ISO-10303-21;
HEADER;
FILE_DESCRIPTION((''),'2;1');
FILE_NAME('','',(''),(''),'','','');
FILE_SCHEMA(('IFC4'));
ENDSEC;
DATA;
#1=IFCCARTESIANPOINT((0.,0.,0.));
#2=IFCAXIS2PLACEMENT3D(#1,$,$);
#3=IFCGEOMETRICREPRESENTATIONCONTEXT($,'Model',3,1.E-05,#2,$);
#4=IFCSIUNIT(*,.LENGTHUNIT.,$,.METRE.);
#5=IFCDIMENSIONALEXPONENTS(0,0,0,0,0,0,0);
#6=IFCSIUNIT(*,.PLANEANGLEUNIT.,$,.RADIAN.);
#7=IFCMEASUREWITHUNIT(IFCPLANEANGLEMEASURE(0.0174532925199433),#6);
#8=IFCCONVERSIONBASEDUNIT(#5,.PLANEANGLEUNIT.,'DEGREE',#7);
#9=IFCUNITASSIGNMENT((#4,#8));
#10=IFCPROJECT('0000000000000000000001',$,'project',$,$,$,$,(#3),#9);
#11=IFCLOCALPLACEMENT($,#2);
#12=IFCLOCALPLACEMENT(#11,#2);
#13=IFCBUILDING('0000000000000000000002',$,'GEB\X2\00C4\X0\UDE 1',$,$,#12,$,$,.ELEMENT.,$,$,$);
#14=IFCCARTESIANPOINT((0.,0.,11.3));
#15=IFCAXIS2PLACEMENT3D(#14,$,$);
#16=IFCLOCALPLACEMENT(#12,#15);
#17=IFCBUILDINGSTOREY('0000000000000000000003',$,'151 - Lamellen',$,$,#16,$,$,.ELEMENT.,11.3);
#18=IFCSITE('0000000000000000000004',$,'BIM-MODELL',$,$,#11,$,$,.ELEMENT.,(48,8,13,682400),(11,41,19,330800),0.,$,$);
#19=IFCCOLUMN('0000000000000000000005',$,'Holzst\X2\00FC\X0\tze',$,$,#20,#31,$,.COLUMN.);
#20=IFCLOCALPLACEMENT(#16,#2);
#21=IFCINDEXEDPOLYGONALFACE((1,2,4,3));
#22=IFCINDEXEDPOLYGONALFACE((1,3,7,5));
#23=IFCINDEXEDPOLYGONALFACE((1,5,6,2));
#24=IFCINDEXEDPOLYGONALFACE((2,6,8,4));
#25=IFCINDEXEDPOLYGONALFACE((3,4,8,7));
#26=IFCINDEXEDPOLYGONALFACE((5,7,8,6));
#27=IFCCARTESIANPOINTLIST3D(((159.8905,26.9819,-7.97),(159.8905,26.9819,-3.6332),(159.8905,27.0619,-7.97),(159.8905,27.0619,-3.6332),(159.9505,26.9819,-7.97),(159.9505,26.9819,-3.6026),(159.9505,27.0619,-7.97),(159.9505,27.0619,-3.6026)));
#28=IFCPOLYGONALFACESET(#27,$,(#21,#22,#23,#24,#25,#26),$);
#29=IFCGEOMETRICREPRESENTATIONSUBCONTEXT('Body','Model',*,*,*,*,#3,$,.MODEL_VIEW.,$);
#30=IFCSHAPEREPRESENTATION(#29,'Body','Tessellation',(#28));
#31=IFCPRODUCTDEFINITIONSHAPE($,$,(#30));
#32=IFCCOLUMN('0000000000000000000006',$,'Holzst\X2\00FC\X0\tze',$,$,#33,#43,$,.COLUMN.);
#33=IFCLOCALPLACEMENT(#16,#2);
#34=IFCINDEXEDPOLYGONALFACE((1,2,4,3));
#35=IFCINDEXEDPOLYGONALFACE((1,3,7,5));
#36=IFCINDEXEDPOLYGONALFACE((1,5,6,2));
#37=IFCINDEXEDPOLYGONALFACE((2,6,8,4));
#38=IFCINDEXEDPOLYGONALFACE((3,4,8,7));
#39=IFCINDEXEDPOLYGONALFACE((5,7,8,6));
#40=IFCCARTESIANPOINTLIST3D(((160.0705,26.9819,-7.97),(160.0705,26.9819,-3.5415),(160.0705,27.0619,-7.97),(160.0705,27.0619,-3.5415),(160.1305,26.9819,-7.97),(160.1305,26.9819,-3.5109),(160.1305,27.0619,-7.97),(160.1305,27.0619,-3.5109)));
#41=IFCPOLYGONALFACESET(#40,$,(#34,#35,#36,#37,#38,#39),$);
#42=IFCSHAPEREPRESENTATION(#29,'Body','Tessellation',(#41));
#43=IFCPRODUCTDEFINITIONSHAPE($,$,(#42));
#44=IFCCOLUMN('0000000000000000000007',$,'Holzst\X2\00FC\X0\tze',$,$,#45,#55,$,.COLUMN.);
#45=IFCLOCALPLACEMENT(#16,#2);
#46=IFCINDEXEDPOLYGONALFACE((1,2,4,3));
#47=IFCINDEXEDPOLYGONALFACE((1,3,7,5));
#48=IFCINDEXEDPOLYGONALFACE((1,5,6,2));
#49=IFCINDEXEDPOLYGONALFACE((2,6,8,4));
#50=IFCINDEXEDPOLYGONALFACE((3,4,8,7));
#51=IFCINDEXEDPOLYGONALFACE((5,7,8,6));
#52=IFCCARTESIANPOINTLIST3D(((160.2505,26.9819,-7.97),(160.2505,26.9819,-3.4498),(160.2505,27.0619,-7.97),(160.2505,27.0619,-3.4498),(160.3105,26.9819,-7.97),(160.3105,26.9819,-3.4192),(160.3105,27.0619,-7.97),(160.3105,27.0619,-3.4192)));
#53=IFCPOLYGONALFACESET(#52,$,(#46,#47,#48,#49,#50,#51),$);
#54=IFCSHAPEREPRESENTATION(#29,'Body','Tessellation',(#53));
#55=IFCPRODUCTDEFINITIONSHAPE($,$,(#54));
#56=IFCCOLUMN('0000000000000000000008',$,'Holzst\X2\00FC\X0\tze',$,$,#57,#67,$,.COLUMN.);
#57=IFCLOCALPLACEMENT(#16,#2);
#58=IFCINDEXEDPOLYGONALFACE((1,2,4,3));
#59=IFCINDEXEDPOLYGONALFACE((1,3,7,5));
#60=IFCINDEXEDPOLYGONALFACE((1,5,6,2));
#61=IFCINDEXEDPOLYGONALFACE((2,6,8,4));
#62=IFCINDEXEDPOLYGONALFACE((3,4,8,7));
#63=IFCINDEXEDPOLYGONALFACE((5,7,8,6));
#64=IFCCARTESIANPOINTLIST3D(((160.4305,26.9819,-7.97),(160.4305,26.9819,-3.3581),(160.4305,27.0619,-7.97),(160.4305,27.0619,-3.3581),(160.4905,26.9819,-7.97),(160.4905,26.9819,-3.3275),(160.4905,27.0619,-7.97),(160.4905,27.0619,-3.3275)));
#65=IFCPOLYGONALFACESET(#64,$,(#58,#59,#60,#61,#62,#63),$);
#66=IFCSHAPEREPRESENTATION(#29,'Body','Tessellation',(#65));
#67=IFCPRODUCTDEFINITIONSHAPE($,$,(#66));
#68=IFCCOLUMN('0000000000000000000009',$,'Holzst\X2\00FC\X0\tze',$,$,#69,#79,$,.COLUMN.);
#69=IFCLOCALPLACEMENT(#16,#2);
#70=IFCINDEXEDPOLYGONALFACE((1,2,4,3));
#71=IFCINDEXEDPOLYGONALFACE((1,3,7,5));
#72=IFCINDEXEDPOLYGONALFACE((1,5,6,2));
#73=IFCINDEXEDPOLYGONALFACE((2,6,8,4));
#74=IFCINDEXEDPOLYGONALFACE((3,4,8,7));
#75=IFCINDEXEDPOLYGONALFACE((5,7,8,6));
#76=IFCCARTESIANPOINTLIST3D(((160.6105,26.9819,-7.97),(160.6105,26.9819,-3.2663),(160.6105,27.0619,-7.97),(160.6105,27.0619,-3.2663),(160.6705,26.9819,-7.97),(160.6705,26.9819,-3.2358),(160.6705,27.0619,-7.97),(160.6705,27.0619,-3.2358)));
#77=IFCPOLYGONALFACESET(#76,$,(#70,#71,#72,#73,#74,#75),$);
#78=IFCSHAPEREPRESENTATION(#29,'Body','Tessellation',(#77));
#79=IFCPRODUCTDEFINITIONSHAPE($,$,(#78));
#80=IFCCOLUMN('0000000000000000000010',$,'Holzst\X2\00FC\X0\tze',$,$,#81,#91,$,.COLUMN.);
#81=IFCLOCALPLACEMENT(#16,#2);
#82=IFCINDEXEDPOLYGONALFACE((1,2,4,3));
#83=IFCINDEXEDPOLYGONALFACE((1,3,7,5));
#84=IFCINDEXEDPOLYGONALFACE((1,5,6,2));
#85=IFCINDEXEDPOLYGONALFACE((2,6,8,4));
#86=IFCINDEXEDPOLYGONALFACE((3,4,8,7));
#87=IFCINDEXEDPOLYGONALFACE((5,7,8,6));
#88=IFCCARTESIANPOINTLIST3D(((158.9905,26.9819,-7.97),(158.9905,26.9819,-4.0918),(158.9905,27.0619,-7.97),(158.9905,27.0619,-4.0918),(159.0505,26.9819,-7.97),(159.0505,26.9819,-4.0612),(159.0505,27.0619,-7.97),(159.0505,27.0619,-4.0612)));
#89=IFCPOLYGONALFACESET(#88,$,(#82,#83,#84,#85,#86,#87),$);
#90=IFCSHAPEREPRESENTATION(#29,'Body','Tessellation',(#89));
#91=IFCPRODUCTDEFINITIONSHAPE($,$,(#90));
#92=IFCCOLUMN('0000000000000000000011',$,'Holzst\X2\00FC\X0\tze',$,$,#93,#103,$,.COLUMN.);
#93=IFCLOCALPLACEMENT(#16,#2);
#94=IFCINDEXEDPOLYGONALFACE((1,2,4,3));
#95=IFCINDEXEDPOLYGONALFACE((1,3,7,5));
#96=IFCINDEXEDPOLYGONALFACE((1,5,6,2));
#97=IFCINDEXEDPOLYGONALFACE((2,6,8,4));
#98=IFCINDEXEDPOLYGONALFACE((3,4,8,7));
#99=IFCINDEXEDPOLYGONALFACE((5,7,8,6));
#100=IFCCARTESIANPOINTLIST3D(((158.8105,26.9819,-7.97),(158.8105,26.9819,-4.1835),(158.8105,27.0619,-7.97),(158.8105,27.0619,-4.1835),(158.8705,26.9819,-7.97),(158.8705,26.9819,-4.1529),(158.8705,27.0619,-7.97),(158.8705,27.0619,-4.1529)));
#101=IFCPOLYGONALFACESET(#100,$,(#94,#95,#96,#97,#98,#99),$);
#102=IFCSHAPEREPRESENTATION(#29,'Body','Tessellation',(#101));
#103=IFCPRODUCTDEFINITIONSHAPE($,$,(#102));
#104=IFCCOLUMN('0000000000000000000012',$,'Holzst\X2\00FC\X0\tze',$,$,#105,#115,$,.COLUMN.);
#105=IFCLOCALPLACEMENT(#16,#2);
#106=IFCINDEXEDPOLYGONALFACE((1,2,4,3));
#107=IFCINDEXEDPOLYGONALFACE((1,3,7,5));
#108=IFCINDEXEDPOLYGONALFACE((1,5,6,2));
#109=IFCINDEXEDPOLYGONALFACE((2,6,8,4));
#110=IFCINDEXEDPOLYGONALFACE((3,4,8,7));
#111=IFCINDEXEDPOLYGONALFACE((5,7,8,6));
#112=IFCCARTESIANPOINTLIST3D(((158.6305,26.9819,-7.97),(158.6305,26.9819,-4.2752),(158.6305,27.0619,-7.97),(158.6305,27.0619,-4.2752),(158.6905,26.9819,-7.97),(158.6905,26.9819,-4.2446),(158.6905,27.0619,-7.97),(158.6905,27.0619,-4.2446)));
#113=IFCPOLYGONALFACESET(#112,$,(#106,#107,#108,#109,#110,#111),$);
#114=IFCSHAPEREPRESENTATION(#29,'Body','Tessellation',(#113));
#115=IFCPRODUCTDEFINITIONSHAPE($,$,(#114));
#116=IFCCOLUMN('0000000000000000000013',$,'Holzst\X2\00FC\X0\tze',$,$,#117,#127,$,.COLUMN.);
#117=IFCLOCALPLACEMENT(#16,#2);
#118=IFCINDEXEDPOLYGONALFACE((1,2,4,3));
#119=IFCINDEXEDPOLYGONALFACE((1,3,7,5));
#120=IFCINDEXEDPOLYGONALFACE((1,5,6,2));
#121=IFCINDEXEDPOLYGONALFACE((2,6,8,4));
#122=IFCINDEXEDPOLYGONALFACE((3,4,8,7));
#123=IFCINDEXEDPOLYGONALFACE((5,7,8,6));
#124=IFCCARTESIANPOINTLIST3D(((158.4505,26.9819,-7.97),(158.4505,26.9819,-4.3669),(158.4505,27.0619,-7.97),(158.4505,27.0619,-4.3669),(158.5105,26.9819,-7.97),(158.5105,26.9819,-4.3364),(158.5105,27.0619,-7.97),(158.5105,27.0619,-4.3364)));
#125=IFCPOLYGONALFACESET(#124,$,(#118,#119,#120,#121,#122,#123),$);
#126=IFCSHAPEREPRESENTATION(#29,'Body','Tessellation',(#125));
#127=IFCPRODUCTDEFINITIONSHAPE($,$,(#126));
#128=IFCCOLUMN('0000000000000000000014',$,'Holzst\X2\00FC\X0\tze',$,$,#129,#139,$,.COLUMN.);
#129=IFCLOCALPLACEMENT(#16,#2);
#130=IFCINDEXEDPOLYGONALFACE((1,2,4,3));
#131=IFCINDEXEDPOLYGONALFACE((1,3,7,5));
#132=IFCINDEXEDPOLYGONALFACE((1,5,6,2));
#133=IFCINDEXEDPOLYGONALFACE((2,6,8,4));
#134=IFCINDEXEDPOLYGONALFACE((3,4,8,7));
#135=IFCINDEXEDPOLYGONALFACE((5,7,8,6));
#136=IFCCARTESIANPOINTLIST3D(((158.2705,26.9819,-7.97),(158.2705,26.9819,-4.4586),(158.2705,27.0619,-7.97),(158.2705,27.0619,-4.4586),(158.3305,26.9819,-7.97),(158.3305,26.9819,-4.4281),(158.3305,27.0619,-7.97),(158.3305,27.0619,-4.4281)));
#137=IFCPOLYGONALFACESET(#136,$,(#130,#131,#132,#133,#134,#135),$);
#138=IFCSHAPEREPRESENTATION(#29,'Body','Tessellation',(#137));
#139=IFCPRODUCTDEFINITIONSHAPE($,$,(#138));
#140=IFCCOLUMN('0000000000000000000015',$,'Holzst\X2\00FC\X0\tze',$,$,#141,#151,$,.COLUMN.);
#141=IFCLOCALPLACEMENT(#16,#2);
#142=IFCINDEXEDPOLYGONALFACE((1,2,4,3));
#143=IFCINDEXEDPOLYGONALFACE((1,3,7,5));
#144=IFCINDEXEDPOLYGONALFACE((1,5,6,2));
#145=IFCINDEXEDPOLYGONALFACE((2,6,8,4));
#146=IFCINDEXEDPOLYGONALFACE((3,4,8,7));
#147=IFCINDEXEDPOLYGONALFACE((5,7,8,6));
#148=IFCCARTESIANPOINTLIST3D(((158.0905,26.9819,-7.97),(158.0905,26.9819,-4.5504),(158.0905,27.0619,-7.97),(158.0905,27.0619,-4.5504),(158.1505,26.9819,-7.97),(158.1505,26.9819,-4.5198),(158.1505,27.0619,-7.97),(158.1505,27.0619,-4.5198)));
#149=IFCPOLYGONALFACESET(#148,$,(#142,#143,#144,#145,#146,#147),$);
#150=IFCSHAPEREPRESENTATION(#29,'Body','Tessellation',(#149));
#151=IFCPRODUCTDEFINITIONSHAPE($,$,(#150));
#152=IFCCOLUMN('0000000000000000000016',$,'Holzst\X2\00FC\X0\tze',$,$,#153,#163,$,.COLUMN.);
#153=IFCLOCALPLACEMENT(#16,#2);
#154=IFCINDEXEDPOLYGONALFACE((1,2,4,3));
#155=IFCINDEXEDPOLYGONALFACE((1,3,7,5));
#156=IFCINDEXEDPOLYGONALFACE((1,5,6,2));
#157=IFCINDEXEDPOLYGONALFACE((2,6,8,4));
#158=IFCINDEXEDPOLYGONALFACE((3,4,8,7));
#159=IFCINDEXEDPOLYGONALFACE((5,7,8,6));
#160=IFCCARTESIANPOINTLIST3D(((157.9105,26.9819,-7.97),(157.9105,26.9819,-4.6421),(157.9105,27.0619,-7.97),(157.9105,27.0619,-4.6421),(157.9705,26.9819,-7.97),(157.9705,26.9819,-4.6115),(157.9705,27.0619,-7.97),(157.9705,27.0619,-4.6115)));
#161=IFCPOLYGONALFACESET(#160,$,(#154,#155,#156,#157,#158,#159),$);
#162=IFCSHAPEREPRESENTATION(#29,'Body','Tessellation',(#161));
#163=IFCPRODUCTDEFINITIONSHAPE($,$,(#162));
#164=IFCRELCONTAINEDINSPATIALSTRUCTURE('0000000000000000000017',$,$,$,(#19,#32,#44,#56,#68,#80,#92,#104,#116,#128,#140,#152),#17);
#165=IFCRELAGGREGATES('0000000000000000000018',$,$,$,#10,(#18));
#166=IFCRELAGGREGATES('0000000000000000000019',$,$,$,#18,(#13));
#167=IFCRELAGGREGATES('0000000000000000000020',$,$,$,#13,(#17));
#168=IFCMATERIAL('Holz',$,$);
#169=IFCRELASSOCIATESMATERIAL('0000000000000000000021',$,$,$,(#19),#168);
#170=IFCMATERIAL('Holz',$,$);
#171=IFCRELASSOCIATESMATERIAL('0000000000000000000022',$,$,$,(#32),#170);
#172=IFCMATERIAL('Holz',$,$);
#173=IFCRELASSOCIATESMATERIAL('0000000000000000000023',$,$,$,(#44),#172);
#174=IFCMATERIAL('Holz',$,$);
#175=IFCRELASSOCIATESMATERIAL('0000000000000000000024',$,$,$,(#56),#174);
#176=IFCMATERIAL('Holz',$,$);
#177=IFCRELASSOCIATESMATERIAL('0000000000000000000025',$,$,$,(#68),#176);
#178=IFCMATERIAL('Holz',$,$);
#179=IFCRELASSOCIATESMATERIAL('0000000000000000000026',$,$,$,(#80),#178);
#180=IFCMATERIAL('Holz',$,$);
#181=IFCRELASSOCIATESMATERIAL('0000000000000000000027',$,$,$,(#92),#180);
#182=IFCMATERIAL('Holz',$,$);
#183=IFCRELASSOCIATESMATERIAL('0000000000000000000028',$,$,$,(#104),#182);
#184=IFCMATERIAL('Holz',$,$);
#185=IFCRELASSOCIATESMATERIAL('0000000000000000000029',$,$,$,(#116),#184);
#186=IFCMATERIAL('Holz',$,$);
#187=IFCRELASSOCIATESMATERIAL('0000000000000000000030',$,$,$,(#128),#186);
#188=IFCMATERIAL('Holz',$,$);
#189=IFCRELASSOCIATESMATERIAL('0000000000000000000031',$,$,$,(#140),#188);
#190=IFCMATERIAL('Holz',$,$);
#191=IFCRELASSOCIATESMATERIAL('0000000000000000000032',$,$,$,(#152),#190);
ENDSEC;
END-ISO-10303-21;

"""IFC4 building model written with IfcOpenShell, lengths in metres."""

from ifc_helpers import new_model, entity, si_unit, converted_unit, frame, frame_2d, origin, origin_with_axes, place, context, subcontext, project, spatial, rectangle, extrude, clip, halfspace, material, element, save


model = new_model("IFC4")

# Units and contexts
model_context = context("Model", 3, precision=1e-05, world=origin())
body_context = subcontext(model_context, "Body", "Model", "MODEL_VIEW")
ifc_project = project(units=[si_unit("LENGTHUNIT", "METRE"), converted_unit("PLANEANGLEUNIT", "DEGREE", entity("IfcPlaneAngleMeasure", 0.0174532925199433), si_unit("PLANEANGLEUNIT", "RADIAN"), dimensions=[0, 0, 0, 0, 0, 0, 0])], contexts=[model_context])

# Site, building, storey
site_placement = place(None, origin())
site = spatial("IfcSite", under=ifc_project, at=site_placement, Name="BIM-MODELL", CompositionType="ELEMENT", RefLatitude=(48, 8, 13, 682400), RefLongitude=(11, 41, 19, 330800), RefElevation=0.0)
building_placement = place(site_placement, origin())
building = spatial("IfcBuilding", under=site, at=building_placement, Name="GEBÄUDE 1", CompositionType="ELEMENT")
storey_placement = place(building_placement, frame((0.0, 0.0, 11.3)))
storey = spatial("IfcBuildingStorey", under=building, at=storey_placement, Name="151 - Lamellen", CompositionType="ELEMENT", Elevation=11.3)

# Columns
ifc_material_1 = material(Name="Holz")
column_1_placement = place(storey_placement, frame((159.8905, 26.9819, -7.97)))
element("IfcColumn", 1, at=column_1_placement, inside=storey, material=ifc_material_1, Name="Holzstütze", PredefinedType="COLUMN", context=body_context, shape_type="Clipping", body=[
    clip(extrude(rectangle(XDim=0.06, YDim=0.08, at=frame_2d((0.03, 0.04), x_axis=(1.0, 0.0))), origin_with_axes(), (0.0, 0.0, 1.0), 4.3674), halfspace(frame((0.03, 0.04, 4.3521), z_axis=(0.45399, 0.0, -0.891007), x_axis=(0.0, -1.0, 0.0)), True)),
])
ifc_material_2 = material(Name="Holz")
column_2_placement = place(storey_placement, frame((160.0705, 26.9819, -7.97)))
element("IfcColumn", 2, at=column_2_placement, inside=storey, material=ifc_material_2, Name="Holzstütze", PredefinedType="COLUMN", context=body_context, shape_type="Clipping", body=[
    clip(extrude(rectangle(XDim=0.06, YDim=0.08, at=frame_2d((0.03, 0.04), x_axis=(1.0, 0.0))), origin_with_axes(), (0.0, 0.0, 1.0), 4.4591), halfspace(frame((0.03, 0.04, 4.4438), z_axis=(0.45399, 0.0, -0.891007), x_axis=(0.0, -1.0, 0.0)), True)),
])
ifc_material_3 = material(Name="Holz")
column_3_placement = place(storey_placement, frame((160.2505, 26.9819, -7.97)))
element("IfcColumn", 3, at=column_3_placement, inside=storey, material=ifc_material_3, Name="Holzstütze", PredefinedType="COLUMN", context=body_context, shape_type="Clipping", body=[
    clip(extrude(rectangle(XDim=0.06, YDim=0.08, at=frame_2d((0.03, 0.04), x_axis=(1.0, 0.0))), origin_with_axes(), (0.0, 0.0, 1.0), 4.5508), halfspace(frame((0.03, 0.04, 4.5355), z_axis=(0.45399, 0.0, -0.891007), x_axis=(0.0, -1.0, 0.0)), True)),
])
ifc_material_4 = material(Name="Holz")
column_4_placement = place(storey_placement, frame((160.4305, 26.9819, -7.97)))
element("IfcColumn", 4, at=column_4_placement, inside=storey, material=ifc_material_4, Name="Holzstütze", PredefinedType="COLUMN", context=body_context, shape_type="Clipping", body=[
    clip(extrude(rectangle(XDim=0.06, YDim=0.08, at=frame_2d((0.03, 0.04), x_axis=(1.0, 0.0))), origin_with_axes(), (0.0, 0.0, 1.0), 4.6425), halfspace(frame((0.03, 0.04, 4.6272), z_axis=(0.45399, 0.0, -0.891007), x_axis=(0.0, -1.0, 0.0)), True)),
])
ifc_material_5 = material(Name="Holz")
column_5_placement = place(storey_placement, frame((160.6105, 26.9819, -7.97)))
element("IfcColumn", 5, at=column_5_placement, inside=storey, material=ifc_material_5, Name="Holzstütze", PredefinedType="COLUMN", context=body_context, shape_type="Clipping", body=[
    clip(extrude(rectangle(XDim=0.06, YDim=0.08, at=frame_2d((0.03, 0.04), x_axis=(1.0, 0.0))), origin_with_axes(), (0.0, 0.0, 1.0), 4.7342), halfspace(frame((0.03, 0.04, 4.7189), z_axis=(0.45399, 0.0, -0.891007), x_axis=(0.0, -1.0, 0.0)), True)),
])
ifc_material_6 = material(Name="Holz")
column_6_placement = place(storey_placement, frame((158.9905, 26.9819, -7.97)))
element("IfcColumn", 6, at=column_6_placement, inside=storey, material=ifc_material_6, Name="Holzstütze", PredefinedType="COLUMN", context=body_context, shape_type="Clipping", body=[
    clip(extrude(rectangle(XDim=0.06, YDim=0.08, at=frame_2d((0.03, 0.04), x_axis=(1.0, 0.0))), origin_with_axes(), (0.0, 0.0, 1.0), 3.9088), halfspace(frame((0.03, 0.04, 3.8935), z_axis=(0.45399, 0.0, -0.891007), x_axis=(0.0, -1.0, 0.0)), True)),
])
ifc_material_7 = material(Name="Holz")
column_7_placement = place(storey_placement, frame((158.8105, 26.9819, -7.97)))
element("IfcColumn", 7, at=column_7_placement, inside=storey, material=ifc_material_7, Name="Holzstütze", PredefinedType="COLUMN", context=body_context, shape_type="Clipping", body=[
    clip(extrude(rectangle(XDim=0.06, YDim=0.08, at=frame_2d((0.03, 0.04), x_axis=(1.0, 0.0))), origin_with_axes(), (0.0, 0.0, 1.0), 3.8171), halfspace(frame((0.03, 0.04, 3.8018), z_axis=(0.45399, 0.0, -0.891007), x_axis=(0.0, -1.0, 0.0)), True)),
])
ifc_material_8 = material(Name="Holz")
column_8_placement = place(storey_placement, frame((158.6305, 26.9819, -7.97)))
element("IfcColumn", 8, at=column_8_placement, inside=storey, material=ifc_material_8, Name="Holzstütze", PredefinedType="COLUMN", context=body_context, shape_type="Clipping", body=[
    clip(extrude(rectangle(XDim=0.06, YDim=0.08, at=frame_2d((0.03, 0.04), x_axis=(1.0, 0.0))), origin_with_axes(), (0.0, 0.0, 1.0), 3.7254), halfspace(frame((0.03, 0.04, 3.7101), z_axis=(0.45399, 0.0, -0.891007), x_axis=(0.0, -1.0, 0.0)), True)),
])
ifc_material_9 = material(Name="Holz")
column_9_placement = place(storey_placement, frame((158.4505, 26.9819, -7.97)))
element("IfcColumn", 9, at=column_9_placement, inside=storey, material=ifc_material_9, Name="Holzstütze", PredefinedType="COLUMN", context=body_context, shape_type="Clipping", body=[
    clip(extrude(rectangle(XDim=0.06, YDim=0.08, at=frame_2d((0.03, 0.04), x_axis=(1.0, 0.0))), origin_with_axes(), (0.0, 0.0, 1.0), 3.6336), halfspace(frame((0.03, 0.04, 3.6184), z_axis=(0.45399, 0.0, -0.891007), x_axis=(0.0, -1.0, 0.0)), True)),
])
ifc_material_10 = material(Name="Holz")
column_10_placement = place(storey_placement, frame((158.2705, 26.9819, -7.97)))
element("IfcColumn", 10, at=column_10_placement, inside=storey, material=ifc_material_10, Name="Holzstütze", PredefinedType="COLUMN", context=body_context, shape_type="Clipping", body=[
    clip(extrude(rectangle(XDim=0.06, YDim=0.08, at=frame_2d((0.03, 0.04), x_axis=(1.0, 0.0))), origin_with_axes(), (0.0, 0.0, 1.0), 3.5419), halfspace(frame((0.03, 0.04, 3.5266), z_axis=(0.45399, 0.0, -0.891007), x_axis=(0.0, -1.0, 0.0)), True)),
])
ifc_material_11 = material(Name="Holz")
column_11_placement = place(storey_placement, frame((158.0905, 26.9819, -7.97)))
element("IfcColumn", 11, at=column_11_placement, inside=storey, material=ifc_material_11, Name="Holzstütze", PredefinedType="COLUMN", context=body_context, shape_type="Clipping", body=[
    clip(extrude(rectangle(XDim=0.06, YDim=0.08, at=frame_2d((0.03, 0.04), x_axis=(1.0, 0.0))), origin_with_axes(), (0.0, 0.0, 1.0), 3.4502), halfspace(frame((0.03, 0.04, 3.4349), z_axis=(0.45399, 0.0, -0.891007), x_axis=(0.0, -1.0, 0.0)), True)),
])
ifc_material_12 = material(Name="Holz")
column_12_placement = place(storey_placement, frame((157.9105, 26.9819, -7.97)))
element("IfcColumn", 12, at=column_12_placement, inside=storey, material=ifc_material_12, Name="Holzstütze", PredefinedType="COLUMN", context=body_context, shape_type="Clipping", body=[
    clip(extrude(rectangle(XDim=0.06, YDim=0.08, at=frame_2d((0.03, 0.04), x_axis=(1.0, 0.0))), origin_with_axes(), (0.0, 0.0, 1.0), 3.3585), halfspace(frame((0.03, 0.04, 3.3432), z_axis=(0.45399, 0.0, -0.891007), x_axis=(0.0, -1.0, 0.0)), True)),
])

save(model, "model.ifc")
